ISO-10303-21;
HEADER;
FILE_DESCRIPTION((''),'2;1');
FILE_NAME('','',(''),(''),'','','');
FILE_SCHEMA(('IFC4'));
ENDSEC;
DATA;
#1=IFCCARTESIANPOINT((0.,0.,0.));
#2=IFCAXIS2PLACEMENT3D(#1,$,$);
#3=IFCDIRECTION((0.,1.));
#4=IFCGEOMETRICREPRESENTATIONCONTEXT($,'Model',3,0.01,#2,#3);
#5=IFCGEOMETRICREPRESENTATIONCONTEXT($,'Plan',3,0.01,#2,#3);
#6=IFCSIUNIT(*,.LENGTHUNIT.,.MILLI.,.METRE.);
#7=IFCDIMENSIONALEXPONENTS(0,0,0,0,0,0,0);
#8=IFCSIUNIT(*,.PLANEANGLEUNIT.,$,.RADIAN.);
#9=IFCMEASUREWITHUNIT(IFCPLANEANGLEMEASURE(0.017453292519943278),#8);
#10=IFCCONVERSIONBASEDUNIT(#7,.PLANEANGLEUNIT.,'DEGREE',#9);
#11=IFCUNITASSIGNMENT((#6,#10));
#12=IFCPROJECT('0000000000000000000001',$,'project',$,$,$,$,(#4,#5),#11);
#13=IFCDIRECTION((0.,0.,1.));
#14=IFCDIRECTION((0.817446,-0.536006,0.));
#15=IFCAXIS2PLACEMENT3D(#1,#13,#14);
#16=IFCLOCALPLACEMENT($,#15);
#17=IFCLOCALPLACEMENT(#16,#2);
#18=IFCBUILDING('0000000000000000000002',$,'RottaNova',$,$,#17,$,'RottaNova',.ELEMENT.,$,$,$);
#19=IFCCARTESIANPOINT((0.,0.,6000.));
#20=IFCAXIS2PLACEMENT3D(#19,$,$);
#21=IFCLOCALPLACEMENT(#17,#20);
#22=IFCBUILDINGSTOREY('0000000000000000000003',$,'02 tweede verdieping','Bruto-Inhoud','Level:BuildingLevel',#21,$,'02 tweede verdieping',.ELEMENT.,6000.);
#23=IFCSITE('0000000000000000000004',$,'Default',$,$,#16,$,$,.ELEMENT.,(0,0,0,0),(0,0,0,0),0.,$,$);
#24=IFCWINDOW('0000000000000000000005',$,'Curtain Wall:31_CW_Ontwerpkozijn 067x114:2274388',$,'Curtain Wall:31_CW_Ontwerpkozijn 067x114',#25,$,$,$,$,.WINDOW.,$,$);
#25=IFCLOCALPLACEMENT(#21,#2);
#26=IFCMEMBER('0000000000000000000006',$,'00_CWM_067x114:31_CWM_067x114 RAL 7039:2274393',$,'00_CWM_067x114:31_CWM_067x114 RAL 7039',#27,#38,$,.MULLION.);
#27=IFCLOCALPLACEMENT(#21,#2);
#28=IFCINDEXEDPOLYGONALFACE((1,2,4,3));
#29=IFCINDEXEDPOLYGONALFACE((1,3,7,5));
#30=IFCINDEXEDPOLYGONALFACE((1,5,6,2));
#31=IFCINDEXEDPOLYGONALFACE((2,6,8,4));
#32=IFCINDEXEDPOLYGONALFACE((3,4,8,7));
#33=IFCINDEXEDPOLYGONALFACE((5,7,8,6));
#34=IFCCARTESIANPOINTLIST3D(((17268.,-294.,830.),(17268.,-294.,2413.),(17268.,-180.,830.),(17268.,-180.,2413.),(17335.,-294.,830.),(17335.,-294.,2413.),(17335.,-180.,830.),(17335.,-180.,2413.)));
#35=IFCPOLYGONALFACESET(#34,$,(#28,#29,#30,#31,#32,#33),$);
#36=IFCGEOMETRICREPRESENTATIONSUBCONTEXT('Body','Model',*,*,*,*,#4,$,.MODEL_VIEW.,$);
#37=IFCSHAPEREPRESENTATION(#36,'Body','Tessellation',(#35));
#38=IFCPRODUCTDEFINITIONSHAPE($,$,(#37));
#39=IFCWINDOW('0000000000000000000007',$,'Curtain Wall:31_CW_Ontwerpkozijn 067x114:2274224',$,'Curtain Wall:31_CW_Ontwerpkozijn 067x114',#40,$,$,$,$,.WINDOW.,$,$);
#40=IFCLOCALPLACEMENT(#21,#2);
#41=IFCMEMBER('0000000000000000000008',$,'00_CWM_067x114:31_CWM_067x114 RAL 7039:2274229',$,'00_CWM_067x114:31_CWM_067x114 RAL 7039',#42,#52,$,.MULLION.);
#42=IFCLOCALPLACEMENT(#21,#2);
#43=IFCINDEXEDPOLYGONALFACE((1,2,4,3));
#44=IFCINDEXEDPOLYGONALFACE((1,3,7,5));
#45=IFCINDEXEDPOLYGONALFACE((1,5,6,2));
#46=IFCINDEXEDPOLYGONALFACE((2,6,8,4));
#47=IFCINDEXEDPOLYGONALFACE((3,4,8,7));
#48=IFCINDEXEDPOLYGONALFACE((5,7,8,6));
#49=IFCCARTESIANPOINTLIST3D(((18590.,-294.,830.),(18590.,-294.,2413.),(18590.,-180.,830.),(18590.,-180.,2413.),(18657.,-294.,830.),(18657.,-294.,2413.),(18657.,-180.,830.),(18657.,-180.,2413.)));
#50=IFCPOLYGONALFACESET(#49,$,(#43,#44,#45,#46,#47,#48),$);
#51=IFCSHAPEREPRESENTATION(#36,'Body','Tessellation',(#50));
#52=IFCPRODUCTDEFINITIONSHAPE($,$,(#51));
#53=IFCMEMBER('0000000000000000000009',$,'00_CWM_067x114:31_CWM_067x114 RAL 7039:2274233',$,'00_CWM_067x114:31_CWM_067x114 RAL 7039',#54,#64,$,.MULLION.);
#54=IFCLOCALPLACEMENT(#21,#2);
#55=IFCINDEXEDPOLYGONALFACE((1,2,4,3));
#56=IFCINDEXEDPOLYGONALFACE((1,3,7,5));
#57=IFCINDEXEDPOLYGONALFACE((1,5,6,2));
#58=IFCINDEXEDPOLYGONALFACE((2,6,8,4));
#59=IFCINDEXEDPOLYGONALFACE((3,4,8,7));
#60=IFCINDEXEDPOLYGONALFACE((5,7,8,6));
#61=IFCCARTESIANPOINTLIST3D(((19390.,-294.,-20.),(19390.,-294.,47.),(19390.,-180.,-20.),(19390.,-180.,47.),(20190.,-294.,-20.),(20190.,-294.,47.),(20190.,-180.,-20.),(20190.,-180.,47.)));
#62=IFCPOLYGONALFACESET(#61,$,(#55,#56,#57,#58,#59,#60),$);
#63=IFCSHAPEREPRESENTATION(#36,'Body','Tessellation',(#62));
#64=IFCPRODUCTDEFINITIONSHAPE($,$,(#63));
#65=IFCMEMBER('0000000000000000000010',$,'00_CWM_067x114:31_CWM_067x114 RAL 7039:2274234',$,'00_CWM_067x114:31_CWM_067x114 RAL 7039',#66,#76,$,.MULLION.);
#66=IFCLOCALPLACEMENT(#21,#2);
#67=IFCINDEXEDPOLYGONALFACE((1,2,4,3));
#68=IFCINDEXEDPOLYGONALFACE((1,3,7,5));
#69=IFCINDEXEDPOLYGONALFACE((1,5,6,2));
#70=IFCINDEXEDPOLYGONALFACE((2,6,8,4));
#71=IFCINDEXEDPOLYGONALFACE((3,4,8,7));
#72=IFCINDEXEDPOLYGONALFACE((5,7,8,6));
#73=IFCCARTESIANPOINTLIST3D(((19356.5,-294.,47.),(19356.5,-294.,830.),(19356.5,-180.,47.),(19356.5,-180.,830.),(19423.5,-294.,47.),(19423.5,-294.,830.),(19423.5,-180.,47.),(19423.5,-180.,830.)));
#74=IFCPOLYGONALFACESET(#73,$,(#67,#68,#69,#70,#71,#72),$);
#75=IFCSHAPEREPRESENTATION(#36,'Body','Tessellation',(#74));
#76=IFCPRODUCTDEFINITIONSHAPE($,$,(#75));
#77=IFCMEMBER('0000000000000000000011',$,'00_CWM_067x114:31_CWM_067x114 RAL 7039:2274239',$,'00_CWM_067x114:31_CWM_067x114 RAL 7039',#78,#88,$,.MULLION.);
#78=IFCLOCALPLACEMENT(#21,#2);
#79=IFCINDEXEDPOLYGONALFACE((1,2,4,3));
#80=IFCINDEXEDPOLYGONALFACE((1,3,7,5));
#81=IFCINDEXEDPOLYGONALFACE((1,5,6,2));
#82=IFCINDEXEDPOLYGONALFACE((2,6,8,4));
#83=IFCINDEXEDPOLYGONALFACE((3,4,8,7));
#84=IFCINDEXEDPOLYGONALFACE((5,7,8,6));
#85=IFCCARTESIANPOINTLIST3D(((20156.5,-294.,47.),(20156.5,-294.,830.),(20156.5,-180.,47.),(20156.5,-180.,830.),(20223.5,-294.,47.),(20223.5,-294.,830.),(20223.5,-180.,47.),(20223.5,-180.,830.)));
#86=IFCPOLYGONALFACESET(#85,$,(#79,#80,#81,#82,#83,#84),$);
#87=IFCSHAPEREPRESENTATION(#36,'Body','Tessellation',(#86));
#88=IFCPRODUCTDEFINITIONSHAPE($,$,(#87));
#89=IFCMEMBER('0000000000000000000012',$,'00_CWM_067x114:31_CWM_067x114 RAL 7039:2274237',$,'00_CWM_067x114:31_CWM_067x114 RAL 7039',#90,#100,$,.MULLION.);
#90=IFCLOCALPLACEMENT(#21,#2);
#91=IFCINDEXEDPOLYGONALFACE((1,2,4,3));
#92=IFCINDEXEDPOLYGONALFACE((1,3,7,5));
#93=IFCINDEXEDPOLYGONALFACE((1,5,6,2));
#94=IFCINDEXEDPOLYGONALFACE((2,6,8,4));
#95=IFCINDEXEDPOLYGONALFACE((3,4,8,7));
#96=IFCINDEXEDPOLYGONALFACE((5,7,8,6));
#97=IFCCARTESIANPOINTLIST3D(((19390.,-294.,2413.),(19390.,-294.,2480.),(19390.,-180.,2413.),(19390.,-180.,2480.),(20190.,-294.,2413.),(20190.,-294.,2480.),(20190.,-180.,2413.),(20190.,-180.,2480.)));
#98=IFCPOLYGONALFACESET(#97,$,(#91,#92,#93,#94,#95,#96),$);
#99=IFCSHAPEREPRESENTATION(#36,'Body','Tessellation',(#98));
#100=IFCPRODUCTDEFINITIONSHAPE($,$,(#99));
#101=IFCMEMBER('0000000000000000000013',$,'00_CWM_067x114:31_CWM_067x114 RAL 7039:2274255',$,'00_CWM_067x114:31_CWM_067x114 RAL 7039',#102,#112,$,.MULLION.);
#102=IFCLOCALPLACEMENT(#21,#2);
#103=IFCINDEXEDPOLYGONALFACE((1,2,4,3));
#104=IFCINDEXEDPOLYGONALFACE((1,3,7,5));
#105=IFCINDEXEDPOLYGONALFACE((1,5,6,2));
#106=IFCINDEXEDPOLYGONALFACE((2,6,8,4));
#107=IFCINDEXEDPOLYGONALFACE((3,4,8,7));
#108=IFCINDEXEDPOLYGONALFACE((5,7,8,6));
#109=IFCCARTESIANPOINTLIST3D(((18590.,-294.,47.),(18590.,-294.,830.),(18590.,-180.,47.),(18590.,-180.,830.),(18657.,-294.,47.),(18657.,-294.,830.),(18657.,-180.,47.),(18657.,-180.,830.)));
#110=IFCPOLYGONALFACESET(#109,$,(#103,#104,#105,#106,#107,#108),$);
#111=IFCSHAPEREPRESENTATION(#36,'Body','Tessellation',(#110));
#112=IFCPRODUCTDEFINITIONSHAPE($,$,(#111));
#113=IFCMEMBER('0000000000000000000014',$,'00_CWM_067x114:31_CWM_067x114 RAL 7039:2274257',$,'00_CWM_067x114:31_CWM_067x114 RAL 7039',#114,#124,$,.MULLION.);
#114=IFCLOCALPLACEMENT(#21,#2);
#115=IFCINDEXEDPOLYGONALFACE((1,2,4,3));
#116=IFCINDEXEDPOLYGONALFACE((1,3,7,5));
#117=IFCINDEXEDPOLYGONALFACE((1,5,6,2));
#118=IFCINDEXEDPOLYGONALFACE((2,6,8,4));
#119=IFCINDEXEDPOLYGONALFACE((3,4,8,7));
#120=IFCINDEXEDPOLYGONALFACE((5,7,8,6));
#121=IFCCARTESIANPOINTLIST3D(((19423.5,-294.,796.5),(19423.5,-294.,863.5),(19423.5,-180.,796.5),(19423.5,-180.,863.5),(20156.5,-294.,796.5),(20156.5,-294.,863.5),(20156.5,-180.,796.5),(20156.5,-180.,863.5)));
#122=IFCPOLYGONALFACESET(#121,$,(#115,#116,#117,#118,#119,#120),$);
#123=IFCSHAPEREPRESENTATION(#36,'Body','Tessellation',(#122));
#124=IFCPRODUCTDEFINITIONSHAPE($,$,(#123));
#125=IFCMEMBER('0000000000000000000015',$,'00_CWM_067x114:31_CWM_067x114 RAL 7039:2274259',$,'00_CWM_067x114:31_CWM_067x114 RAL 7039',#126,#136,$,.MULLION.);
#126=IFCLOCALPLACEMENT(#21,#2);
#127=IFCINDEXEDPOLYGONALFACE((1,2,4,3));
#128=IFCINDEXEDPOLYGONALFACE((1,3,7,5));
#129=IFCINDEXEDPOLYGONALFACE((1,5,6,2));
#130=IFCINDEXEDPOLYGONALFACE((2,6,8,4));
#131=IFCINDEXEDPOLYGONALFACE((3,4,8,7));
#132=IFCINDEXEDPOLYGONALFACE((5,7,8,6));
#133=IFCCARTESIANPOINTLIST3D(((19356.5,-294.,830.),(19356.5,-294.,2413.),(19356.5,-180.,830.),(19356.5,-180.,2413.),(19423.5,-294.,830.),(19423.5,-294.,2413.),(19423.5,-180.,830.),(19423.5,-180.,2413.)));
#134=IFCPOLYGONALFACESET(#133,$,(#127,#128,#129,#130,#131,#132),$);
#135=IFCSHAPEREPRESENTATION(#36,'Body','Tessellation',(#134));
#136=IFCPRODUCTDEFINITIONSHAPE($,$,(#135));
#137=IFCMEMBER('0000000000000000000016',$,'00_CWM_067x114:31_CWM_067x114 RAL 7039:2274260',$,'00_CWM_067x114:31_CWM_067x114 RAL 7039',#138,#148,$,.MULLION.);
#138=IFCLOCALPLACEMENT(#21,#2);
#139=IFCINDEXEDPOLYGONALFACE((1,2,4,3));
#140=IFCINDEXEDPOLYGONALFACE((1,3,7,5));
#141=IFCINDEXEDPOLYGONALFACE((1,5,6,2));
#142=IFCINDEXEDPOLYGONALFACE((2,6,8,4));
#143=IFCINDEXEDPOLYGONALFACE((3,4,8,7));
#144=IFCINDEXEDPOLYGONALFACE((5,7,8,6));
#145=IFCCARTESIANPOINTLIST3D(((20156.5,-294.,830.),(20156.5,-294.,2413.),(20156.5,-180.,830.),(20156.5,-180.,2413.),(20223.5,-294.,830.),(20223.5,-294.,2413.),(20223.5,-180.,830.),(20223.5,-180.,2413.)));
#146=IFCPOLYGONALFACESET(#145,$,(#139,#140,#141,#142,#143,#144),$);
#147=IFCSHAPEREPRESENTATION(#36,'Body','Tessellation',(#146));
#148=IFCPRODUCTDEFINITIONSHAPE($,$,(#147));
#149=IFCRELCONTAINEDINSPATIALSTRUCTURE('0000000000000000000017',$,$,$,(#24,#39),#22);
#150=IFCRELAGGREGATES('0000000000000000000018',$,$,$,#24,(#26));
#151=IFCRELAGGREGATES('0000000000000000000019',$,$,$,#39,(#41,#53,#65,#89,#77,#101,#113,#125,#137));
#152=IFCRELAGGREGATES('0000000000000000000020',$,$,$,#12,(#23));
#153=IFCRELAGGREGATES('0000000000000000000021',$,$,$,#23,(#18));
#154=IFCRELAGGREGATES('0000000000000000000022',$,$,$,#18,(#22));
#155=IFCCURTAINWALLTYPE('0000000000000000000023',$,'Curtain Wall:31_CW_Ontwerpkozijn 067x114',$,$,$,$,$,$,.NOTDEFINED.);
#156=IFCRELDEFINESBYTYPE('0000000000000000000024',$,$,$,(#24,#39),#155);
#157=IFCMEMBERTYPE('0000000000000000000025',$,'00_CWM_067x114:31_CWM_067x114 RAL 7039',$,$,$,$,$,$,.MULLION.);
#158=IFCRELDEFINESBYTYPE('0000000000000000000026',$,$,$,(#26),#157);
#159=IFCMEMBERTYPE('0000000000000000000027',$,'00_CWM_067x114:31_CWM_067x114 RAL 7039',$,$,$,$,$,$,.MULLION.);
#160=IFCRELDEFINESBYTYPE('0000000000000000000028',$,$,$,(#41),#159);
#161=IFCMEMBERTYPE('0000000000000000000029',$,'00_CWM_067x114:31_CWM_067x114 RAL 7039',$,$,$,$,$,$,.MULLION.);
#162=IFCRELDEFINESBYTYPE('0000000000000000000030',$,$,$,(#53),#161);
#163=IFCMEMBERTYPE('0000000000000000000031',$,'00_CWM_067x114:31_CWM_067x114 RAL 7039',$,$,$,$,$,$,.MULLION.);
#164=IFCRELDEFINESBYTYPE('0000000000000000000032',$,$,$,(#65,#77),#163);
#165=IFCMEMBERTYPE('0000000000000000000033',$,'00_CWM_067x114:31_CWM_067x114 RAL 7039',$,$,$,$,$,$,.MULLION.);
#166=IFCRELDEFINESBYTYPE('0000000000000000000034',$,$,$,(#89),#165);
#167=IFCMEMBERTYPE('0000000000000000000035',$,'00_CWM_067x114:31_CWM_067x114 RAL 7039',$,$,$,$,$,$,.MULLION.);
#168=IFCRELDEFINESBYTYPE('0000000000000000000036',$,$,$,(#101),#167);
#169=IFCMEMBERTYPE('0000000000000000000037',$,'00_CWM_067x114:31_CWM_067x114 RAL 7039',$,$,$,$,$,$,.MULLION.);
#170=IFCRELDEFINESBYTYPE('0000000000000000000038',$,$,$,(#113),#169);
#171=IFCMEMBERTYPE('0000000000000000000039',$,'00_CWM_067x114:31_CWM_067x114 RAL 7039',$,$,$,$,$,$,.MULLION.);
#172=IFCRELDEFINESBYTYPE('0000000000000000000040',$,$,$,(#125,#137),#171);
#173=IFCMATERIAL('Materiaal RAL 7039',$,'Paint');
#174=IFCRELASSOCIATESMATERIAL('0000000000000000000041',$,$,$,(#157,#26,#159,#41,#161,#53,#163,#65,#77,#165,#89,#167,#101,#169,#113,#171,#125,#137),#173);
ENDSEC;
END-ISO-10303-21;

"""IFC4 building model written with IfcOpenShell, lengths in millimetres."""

from ifc_helpers import new_model, entity, si_unit, converted_unit, direction, frame, origin, place, context, subcontext, project, spatial, indexed_curve, outline, extrude, source, transform, mapped, material, type_object, type_shapes, element, aggregate, save


model = new_model("IFC4")

# Units and contexts
model_context = context("Model", 3, precision=0.01, world=origin(), true_north=direction((0.0, 1.0)))
plan_context = context("Plan", 3, precision=0.01, world=origin(), true_north=direction((0.0, 1.0)))
body_context = subcontext(model_context, "Body", "Model", "MODEL_VIEW")
ifc_project = project(units=[si_unit("LENGTHUNIT", "METRE", prefix="MILLI"), converted_unit("PLANEANGLEUNIT", "DEGREE", entity("IfcPlaneAngleMeasure", 0.017453292519943278), si_unit("PLANEANGLEUNIT", "RADIAN"), dimensions=[0, 0, 0, 0, 0, 0, 0])], contexts=[model_context, plan_context])

# Site, building, storey
site_placement = place(None, frame((0.0, 0.0, 0.0), z_axis=(0.0, 0.0, 1.0), x_axis=(0.817446, -0.536006, 0.0)))
site = spatial("IfcSite", under=ifc_project, at=site_placement, Name="Default", CompositionType="ELEMENT", RefLatitude=(0, 0, 0, 0), RefLongitude=(0, 0, 0, 0), RefElevation=0.0)
building_placement = place(site_placement, origin())
building = spatial("IfcBuilding", under=site, at=building_placement, Name="RottaNova", LongName="RottaNova", CompositionType="ELEMENT")
storey_placement = place(building_placement, frame((0.0, 0.0, 6000.0)))
storey = spatial("IfcBuildingStorey", under=building, at=storey_placement, Name="02 tweede verdieping", Description="Bruto-Inhoud", ObjectType="Level:BuildingLevel", LongName="02 tweede verdieping", CompositionType="ELEMENT", Elevation=6000.0)

# Window, member
curtain_wall_type = type_object("IfcCurtainWallType", Name="Curtain Wall:31_CW_Ontwerpkozijn 067x114", PredefinedType="NOTDEFINED")
window_1_placement = place(storey_placement, frame((0.0, 0.0, -6000.0)))
window_1 = element("IfcWindow", 1, at=window_1_placement, inside=storey, type_object=curtain_wall_type, Name="Curtain Wall:31_CW_Ontwerpkozijn 067x114:2274388", ObjectType="Curtain Wall:31_CW_Ontwerpkozijn 067x114", PredefinedType="WINDOW")
ifc_material_1 = material(Name="Materiaal RAL 7039", Category="Paint")
member_type_1 = type_object("IfcMemberType", Name="00_CWM_067x114:31_CWM_067x114 RAL 7039", PredefinedType="MULLION", material=ifc_material_1)
shared_shape_1 = source(origin(), body_context, "Body", "SweptSolid", [
    extrude(outline(indexed_curve([(-33.5, -57.0), (33.5, -57.0), (33.5, 57.0), (-33.5, 57.0), (-33.5, -57.0)], self_intersect=False)), frame((-33.5, -57.0, -1583.0), z_axis=(0.0, 0.0, 1.0), x_axis=(-1.0, 0.0, 0.0)), (0.0, 0.0, 1.0), 1583.0),
])
type_shapes(member_type_1, [shared_shape_1])
member_1_placement = place(window_1_placement, frame((17335.0, -180.0, 8413.0)))
member_1 = element("IfcMember", 2, at=member_1_placement, type_object=member_type_1, material=ifc_material_1, Name="00_CWM_067x114:31_CWM_067x114 RAL 7039:2274393", ObjectType="00_CWM_067x114:31_CWM_067x114 RAL 7039", PredefinedType="MULLION", context=body_context, shape_type="MappedRepresentation", body=[
    mapped(shared_shape_1, transform((0.0, 0.0, 0.0), scale=1.0)),
])

# Window, members
window_2_placement = place(storey_placement, frame((0.0, 0.0, -6000.0)))
window_2 = element("IfcWindow", 3, at=window_2_placement, inside=storey, type_object=curtain_wall_type, Name="Curtain Wall:31_CW_Ontwerpkozijn 067x114:2274224", ObjectType="Curtain Wall:31_CW_Ontwerpkozijn 067x114", PredefinedType="WINDOW")
member_type_2 = type_object("IfcMemberType", Name="00_CWM_067x114:31_CWM_067x114 RAL 7039", PredefinedType="MULLION", material=ifc_material_1)
shared_shape_2 = source(origin(), body_context, "Body", "SweptSolid", [
    extrude(outline(indexed_curve([(-33.5, -57.0), (33.5, -57.0), (33.5, 57.0), (-33.5, 57.0), (-33.5, -57.0)], self_intersect=False)), frame((-33.5, 57.0, -1583.0), z_axis=(0.0, 0.0, 1.0), x_axis=(-1.0, 0.0, 0.0)), (0.0, 0.0, 1.0), 1583.0),
])
type_shapes(member_type_2, [shared_shape_2])
member_2_placement = place(window_2_placement, frame((18590.0, -180.0, 8413.0), z_axis=(0.0, 0.0, 1.0), x_axis=(-1.0, 0.0, 0.0)))
member_2 = element("IfcMember", 4, at=member_2_placement, type_object=member_type_2, material=ifc_material_1, Name="00_CWM_067x114:31_CWM_067x114 RAL 7039:2274229", ObjectType="00_CWM_067x114:31_CWM_067x114 RAL 7039", PredefinedType="MULLION", context=body_context, shape_type="MappedRepresentation", body=[
    mapped(shared_shape_2, transform((0.0, 0.0, 0.0), scale=1.0)),
])
member_type_3 = type_object("IfcMemberType", Name="00_CWM_067x114:31_CWM_067x114 RAL 7039", PredefinedType="MULLION", material=ifc_material_1)
shared_shape_3 = source(origin(), body_context, "Body", "SweptSolid", [
    extrude(outline(indexed_curve([(-33.5, -57.0), (33.5, -57.0), (33.5, 57.0), (-33.5, 57.0), (-33.5, -57.0)], self_intersect=False)), frame((-33.5, 57.0, -800.0), z_axis=(0.0, 0.0, 1.0), x_axis=(-1.0, 0.0, 0.0)), (0.0, 0.0, 1.0), 800.0),
])
type_shapes(member_type_3, [shared_shape_3])
member_3_placement = place(window_2_placement, frame((19390.0, -180.0, 5980.0), z_axis=(-1.0, 0.0, 0.0), x_axis=(0.0, 0.0, -1.0)))
member_3 = element("IfcMember", 5, at=member_3_placement, type_object=member_type_3, material=ifc_material_1, Name="00_CWM_067x114:31_CWM_067x114 RAL 7039:2274233", ObjectType="00_CWM_067x114:31_CWM_067x114 RAL 7039", PredefinedType="MULLION", context=body_context, shape_type="MappedRepresentation", body=[
    mapped(shared_shape_3, transform((0.0, 0.0, 0.0), scale=1.0)),
])
member_type_4 = type_object("IfcMemberType", Name="00_CWM_067x114:31_CWM_067x114 RAL 7039", PredefinedType="MULLION", material=ifc_material_1)
shared_shape_4 = source(origin(), body_context, "Body", "SweptSolid", [
    extrude(outline(indexed_curve([(-33.5, -57.0), (33.5, -57.0), (33.5, 57.0), (-33.5, 57.0), (-33.5, -57.0)], self_intersect=False)), frame((0.0, 57.0, -783.0), z_axis=(0.0, 0.0, 1.0), x_axis=(-1.0, 0.0, 0.0)), (0.0, 0.0, 1.0), 783.0),
])
type_shapes(member_type_4, [shared_shape_4])
member_4_placement = place(window_2_placement, frame((19390.0, -180.0, 6047.0), z_axis=(0.0, 0.0, -1.0), x_axis=(1.0, 0.0, 0.0)))
member_4 = element("IfcMember", 6, at=member_4_placement, type_object=member_type_4, material=ifc_material_1, Name="00_CWM_067x114:31_CWM_067x114 RAL 7039:2274234", ObjectType="00_CWM_067x114:31_CWM_067x114 RAL 7039", PredefinedType="MULLION", context=body_context, shape_type="MappedRepresentation", body=[
    mapped(shared_shape_4, transform((0.0, 0.0, 0.0), scale=1.0)),
])
member_5_placement = place(window_2_placement, frame((20190.0, -180.0, 6047.0), z_axis=(0.0, 0.0, -1.0), x_axis=(1.0, 0.0, 0.0)))
member_5 = element("IfcMember", 7, at=member_5_placement, type_object=member_type_4, material=ifc_material_1, Name="00_CWM_067x114:31_CWM_067x114 RAL 7039:2274239", ObjectType="00_CWM_067x114:31_CWM_067x114 RAL 7039", PredefinedType="MULLION", context=body_context, shape_type="MappedRepresentation", body=[
    mapped(shared_shape_4, transform((0.0, 0.0, 0.0), scale=1.0)),
])
member_type_5 = type_object("IfcMemberType", Name="00_CWM_067x114:31_CWM_067x114 RAL 7039", PredefinedType="MULLION", material=ifc_material_1)
shared_shape_5 = source(origin(), body_context, "Body", "SweptSolid", [
    extrude(outline(indexed_curve([(-33.5, -57.0), (33.5, -57.0), (33.5, 57.0), (-33.5, 57.0), (-33.5, -57.0)], self_intersect=False)), frame((-33.5, 57.0, -800.0), z_axis=(0.0, 0.0, 1.0), x_axis=(-1.0, 0.0, 0.0)), (0.0, 0.0, 1.0), 800.0),
])
type_shapes(member_type_5, [shared_shape_5])
member_6_placement = place(window_2_placement, frame((20190.0, -180.0, 8480.0), z_axis=(1.0, 0.0, 0.0), x_axis=(0.0, 0.0, 1.0)))
member_6 = element("IfcMember", 8, at=member_6_placement, type_object=member_type_5, material=ifc_material_1, Name="00_CWM_067x114:31_CWM_067x114 RAL 7039:2274237", ObjectType="00_CWM_067x114:31_CWM_067x114 RAL 7039", PredefinedType="MULLION", context=body_context, shape_type="MappedRepresentation", body=[
    mapped(shared_shape_5, transform((0.0, 0.0, 0.0), scale=1.0)),
])
member_type_6 = type_object("IfcMemberType", Name="00_CWM_067x114:31_CWM_067x114 RAL 7039", PredefinedType="MULLION", material=ifc_material_1)
shared_shape_6 = source(origin(), body_context, "Body", "SweptSolid", [
    extrude(outline(indexed_curve([(-33.5, -57.0), (33.5, -57.0), (33.5, 57.0), (-33.5, 57.0), (-33.5, -57.0)], self_intersect=False)), frame((-33.5, 57.0, -783.0), z_axis=(0.0, 0.0, 1.0), x_axis=(-1.0, 0.0, 0.0)), (0.0, 0.0, 1.0), 783.0),
])
type_shapes(member_type_6, [shared_shape_6])
member_7_placement = place(window_2_placement, frame((18590.0, -180.0, 6830.0), z_axis=(0.0, 0.0, 1.0), x_axis=(-1.0, 0.0, 0.0)))
member_7 = element("IfcMember", 9, at=member_7_placement, type_object=member_type_6, material=ifc_material_1, Name="00_CWM_067x114:31_CWM_067x114 RAL 7039:2274255", ObjectType="00_CWM_067x114:31_CWM_067x114 RAL 7039", PredefinedType="MULLION", context=body_context, shape_type="MappedRepresentation", body=[
    mapped(shared_shape_6, transform((0.0, 0.0, 0.0), scale=1.0)),
])
member_type_7 = type_object("IfcMemberType", Name="00_CWM_067x114:31_CWM_067x114 RAL 7039", PredefinedType="MULLION", material=ifc_material_1)
shared_shape_7 = source(origin(), body_context, "Body", "SweptSolid", [
    extrude(outline(indexed_curve([(-33.5, -57.0), (33.5, -57.0), (33.5, 57.0), (-33.5, 57.0), (-33.5, -57.0)], self_intersect=False)), frame((0.0, 57.0, -733.0), z_axis=(0.0, 0.0, 1.0), x_axis=(-1.0, 0.0, 0.0)), (0.0, 0.0, 1.0), 733.0),
])
type_shapes(member_type_7, [shared_shape_7])
member_8_placement = place(window_2_placement, frame((20156.5, -180.0, 6830.0), z_axis=(1.0, 0.0, 0.0), x_axis=(0.0, 0.0, 1.0)))
member_8 = element("IfcMember", 10, at=member_8_placement, type_object=member_type_7, material=ifc_material_1, Name="00_CWM_067x114:31_CWM_067x114 RAL 7039:2274257", ObjectType="00_CWM_067x114:31_CWM_067x114 RAL 7039", PredefinedType="MULLION", context=body_context, shape_type="MappedRepresentation", body=[
    mapped(shared_shape_7, transform((0.0, 0.0, 0.0), scale=1.0)),
])
member_type_8 = type_object("IfcMemberType", Name="00_CWM_067x114:31_CWM_067x114 RAL 7039", PredefinedType="MULLION", material=ifc_material_1)
shared_shape_8 = source(origin(), body_context, "Body", "SweptSolid", [
    extrude(outline(indexed_curve([(-33.5, -57.0), (33.5, -57.0), (33.5, 57.0), (-33.5, 57.0), (-33.5, -57.0)], self_intersect=False)), frame((0.0, 57.0, -1583.0), z_axis=(0.0, 0.0, 1.0), x_axis=(-1.0, 0.0, 0.0)), (0.0, 0.0, 1.0), 1583.0),
])
type_shapes(member_type_8, [shared_shape_8])
member_9_placement = place(window_2_placement, frame((19390.0, -180.0, 6830.0), z_axis=(0.0, 0.0, -1.0), x_axis=(1.0, 0.0, 0.0)))
member_9 = element("IfcMember", 11, at=member_9_placement, type_object=member_type_8, material=ifc_material_1, Name="00_CWM_067x114:31_CWM_067x114 RAL 7039:2274259", ObjectType="00_CWM_067x114:31_CWM_067x114 RAL 7039", PredefinedType="MULLION", context=body_context, shape_type="MappedRepresentation", body=[
    mapped(shared_shape_8, transform((0.0, 0.0, 0.0), scale=1.0)),
])
member_10_placement = place(window_2_placement, frame((20190.0, -180.0, 6830.0), z_axis=(0.0, 0.0, -1.0), x_axis=(1.0, 0.0, 0.0)))
member_10 = element("IfcMember", 12, at=member_10_placement, type_object=member_type_8, material=ifc_material_1, Name="00_CWM_067x114:31_CWM_067x114 RAL 7039:2274260", ObjectType="00_CWM_067x114:31_CWM_067x114 RAL 7039", PredefinedType="MULLION", context=body_context, shape_type="MappedRepresentation", body=[
    mapped(shared_shape_8, transform((0.0, 0.0, 0.0), scale=1.0)),
])

aggregate(window_1, [member_1])

aggregate(window_2, [member_2, member_3, member_4, member_6, member_5, member_7, member_8, member_9, member_10])

save(model, "model.ifc")
